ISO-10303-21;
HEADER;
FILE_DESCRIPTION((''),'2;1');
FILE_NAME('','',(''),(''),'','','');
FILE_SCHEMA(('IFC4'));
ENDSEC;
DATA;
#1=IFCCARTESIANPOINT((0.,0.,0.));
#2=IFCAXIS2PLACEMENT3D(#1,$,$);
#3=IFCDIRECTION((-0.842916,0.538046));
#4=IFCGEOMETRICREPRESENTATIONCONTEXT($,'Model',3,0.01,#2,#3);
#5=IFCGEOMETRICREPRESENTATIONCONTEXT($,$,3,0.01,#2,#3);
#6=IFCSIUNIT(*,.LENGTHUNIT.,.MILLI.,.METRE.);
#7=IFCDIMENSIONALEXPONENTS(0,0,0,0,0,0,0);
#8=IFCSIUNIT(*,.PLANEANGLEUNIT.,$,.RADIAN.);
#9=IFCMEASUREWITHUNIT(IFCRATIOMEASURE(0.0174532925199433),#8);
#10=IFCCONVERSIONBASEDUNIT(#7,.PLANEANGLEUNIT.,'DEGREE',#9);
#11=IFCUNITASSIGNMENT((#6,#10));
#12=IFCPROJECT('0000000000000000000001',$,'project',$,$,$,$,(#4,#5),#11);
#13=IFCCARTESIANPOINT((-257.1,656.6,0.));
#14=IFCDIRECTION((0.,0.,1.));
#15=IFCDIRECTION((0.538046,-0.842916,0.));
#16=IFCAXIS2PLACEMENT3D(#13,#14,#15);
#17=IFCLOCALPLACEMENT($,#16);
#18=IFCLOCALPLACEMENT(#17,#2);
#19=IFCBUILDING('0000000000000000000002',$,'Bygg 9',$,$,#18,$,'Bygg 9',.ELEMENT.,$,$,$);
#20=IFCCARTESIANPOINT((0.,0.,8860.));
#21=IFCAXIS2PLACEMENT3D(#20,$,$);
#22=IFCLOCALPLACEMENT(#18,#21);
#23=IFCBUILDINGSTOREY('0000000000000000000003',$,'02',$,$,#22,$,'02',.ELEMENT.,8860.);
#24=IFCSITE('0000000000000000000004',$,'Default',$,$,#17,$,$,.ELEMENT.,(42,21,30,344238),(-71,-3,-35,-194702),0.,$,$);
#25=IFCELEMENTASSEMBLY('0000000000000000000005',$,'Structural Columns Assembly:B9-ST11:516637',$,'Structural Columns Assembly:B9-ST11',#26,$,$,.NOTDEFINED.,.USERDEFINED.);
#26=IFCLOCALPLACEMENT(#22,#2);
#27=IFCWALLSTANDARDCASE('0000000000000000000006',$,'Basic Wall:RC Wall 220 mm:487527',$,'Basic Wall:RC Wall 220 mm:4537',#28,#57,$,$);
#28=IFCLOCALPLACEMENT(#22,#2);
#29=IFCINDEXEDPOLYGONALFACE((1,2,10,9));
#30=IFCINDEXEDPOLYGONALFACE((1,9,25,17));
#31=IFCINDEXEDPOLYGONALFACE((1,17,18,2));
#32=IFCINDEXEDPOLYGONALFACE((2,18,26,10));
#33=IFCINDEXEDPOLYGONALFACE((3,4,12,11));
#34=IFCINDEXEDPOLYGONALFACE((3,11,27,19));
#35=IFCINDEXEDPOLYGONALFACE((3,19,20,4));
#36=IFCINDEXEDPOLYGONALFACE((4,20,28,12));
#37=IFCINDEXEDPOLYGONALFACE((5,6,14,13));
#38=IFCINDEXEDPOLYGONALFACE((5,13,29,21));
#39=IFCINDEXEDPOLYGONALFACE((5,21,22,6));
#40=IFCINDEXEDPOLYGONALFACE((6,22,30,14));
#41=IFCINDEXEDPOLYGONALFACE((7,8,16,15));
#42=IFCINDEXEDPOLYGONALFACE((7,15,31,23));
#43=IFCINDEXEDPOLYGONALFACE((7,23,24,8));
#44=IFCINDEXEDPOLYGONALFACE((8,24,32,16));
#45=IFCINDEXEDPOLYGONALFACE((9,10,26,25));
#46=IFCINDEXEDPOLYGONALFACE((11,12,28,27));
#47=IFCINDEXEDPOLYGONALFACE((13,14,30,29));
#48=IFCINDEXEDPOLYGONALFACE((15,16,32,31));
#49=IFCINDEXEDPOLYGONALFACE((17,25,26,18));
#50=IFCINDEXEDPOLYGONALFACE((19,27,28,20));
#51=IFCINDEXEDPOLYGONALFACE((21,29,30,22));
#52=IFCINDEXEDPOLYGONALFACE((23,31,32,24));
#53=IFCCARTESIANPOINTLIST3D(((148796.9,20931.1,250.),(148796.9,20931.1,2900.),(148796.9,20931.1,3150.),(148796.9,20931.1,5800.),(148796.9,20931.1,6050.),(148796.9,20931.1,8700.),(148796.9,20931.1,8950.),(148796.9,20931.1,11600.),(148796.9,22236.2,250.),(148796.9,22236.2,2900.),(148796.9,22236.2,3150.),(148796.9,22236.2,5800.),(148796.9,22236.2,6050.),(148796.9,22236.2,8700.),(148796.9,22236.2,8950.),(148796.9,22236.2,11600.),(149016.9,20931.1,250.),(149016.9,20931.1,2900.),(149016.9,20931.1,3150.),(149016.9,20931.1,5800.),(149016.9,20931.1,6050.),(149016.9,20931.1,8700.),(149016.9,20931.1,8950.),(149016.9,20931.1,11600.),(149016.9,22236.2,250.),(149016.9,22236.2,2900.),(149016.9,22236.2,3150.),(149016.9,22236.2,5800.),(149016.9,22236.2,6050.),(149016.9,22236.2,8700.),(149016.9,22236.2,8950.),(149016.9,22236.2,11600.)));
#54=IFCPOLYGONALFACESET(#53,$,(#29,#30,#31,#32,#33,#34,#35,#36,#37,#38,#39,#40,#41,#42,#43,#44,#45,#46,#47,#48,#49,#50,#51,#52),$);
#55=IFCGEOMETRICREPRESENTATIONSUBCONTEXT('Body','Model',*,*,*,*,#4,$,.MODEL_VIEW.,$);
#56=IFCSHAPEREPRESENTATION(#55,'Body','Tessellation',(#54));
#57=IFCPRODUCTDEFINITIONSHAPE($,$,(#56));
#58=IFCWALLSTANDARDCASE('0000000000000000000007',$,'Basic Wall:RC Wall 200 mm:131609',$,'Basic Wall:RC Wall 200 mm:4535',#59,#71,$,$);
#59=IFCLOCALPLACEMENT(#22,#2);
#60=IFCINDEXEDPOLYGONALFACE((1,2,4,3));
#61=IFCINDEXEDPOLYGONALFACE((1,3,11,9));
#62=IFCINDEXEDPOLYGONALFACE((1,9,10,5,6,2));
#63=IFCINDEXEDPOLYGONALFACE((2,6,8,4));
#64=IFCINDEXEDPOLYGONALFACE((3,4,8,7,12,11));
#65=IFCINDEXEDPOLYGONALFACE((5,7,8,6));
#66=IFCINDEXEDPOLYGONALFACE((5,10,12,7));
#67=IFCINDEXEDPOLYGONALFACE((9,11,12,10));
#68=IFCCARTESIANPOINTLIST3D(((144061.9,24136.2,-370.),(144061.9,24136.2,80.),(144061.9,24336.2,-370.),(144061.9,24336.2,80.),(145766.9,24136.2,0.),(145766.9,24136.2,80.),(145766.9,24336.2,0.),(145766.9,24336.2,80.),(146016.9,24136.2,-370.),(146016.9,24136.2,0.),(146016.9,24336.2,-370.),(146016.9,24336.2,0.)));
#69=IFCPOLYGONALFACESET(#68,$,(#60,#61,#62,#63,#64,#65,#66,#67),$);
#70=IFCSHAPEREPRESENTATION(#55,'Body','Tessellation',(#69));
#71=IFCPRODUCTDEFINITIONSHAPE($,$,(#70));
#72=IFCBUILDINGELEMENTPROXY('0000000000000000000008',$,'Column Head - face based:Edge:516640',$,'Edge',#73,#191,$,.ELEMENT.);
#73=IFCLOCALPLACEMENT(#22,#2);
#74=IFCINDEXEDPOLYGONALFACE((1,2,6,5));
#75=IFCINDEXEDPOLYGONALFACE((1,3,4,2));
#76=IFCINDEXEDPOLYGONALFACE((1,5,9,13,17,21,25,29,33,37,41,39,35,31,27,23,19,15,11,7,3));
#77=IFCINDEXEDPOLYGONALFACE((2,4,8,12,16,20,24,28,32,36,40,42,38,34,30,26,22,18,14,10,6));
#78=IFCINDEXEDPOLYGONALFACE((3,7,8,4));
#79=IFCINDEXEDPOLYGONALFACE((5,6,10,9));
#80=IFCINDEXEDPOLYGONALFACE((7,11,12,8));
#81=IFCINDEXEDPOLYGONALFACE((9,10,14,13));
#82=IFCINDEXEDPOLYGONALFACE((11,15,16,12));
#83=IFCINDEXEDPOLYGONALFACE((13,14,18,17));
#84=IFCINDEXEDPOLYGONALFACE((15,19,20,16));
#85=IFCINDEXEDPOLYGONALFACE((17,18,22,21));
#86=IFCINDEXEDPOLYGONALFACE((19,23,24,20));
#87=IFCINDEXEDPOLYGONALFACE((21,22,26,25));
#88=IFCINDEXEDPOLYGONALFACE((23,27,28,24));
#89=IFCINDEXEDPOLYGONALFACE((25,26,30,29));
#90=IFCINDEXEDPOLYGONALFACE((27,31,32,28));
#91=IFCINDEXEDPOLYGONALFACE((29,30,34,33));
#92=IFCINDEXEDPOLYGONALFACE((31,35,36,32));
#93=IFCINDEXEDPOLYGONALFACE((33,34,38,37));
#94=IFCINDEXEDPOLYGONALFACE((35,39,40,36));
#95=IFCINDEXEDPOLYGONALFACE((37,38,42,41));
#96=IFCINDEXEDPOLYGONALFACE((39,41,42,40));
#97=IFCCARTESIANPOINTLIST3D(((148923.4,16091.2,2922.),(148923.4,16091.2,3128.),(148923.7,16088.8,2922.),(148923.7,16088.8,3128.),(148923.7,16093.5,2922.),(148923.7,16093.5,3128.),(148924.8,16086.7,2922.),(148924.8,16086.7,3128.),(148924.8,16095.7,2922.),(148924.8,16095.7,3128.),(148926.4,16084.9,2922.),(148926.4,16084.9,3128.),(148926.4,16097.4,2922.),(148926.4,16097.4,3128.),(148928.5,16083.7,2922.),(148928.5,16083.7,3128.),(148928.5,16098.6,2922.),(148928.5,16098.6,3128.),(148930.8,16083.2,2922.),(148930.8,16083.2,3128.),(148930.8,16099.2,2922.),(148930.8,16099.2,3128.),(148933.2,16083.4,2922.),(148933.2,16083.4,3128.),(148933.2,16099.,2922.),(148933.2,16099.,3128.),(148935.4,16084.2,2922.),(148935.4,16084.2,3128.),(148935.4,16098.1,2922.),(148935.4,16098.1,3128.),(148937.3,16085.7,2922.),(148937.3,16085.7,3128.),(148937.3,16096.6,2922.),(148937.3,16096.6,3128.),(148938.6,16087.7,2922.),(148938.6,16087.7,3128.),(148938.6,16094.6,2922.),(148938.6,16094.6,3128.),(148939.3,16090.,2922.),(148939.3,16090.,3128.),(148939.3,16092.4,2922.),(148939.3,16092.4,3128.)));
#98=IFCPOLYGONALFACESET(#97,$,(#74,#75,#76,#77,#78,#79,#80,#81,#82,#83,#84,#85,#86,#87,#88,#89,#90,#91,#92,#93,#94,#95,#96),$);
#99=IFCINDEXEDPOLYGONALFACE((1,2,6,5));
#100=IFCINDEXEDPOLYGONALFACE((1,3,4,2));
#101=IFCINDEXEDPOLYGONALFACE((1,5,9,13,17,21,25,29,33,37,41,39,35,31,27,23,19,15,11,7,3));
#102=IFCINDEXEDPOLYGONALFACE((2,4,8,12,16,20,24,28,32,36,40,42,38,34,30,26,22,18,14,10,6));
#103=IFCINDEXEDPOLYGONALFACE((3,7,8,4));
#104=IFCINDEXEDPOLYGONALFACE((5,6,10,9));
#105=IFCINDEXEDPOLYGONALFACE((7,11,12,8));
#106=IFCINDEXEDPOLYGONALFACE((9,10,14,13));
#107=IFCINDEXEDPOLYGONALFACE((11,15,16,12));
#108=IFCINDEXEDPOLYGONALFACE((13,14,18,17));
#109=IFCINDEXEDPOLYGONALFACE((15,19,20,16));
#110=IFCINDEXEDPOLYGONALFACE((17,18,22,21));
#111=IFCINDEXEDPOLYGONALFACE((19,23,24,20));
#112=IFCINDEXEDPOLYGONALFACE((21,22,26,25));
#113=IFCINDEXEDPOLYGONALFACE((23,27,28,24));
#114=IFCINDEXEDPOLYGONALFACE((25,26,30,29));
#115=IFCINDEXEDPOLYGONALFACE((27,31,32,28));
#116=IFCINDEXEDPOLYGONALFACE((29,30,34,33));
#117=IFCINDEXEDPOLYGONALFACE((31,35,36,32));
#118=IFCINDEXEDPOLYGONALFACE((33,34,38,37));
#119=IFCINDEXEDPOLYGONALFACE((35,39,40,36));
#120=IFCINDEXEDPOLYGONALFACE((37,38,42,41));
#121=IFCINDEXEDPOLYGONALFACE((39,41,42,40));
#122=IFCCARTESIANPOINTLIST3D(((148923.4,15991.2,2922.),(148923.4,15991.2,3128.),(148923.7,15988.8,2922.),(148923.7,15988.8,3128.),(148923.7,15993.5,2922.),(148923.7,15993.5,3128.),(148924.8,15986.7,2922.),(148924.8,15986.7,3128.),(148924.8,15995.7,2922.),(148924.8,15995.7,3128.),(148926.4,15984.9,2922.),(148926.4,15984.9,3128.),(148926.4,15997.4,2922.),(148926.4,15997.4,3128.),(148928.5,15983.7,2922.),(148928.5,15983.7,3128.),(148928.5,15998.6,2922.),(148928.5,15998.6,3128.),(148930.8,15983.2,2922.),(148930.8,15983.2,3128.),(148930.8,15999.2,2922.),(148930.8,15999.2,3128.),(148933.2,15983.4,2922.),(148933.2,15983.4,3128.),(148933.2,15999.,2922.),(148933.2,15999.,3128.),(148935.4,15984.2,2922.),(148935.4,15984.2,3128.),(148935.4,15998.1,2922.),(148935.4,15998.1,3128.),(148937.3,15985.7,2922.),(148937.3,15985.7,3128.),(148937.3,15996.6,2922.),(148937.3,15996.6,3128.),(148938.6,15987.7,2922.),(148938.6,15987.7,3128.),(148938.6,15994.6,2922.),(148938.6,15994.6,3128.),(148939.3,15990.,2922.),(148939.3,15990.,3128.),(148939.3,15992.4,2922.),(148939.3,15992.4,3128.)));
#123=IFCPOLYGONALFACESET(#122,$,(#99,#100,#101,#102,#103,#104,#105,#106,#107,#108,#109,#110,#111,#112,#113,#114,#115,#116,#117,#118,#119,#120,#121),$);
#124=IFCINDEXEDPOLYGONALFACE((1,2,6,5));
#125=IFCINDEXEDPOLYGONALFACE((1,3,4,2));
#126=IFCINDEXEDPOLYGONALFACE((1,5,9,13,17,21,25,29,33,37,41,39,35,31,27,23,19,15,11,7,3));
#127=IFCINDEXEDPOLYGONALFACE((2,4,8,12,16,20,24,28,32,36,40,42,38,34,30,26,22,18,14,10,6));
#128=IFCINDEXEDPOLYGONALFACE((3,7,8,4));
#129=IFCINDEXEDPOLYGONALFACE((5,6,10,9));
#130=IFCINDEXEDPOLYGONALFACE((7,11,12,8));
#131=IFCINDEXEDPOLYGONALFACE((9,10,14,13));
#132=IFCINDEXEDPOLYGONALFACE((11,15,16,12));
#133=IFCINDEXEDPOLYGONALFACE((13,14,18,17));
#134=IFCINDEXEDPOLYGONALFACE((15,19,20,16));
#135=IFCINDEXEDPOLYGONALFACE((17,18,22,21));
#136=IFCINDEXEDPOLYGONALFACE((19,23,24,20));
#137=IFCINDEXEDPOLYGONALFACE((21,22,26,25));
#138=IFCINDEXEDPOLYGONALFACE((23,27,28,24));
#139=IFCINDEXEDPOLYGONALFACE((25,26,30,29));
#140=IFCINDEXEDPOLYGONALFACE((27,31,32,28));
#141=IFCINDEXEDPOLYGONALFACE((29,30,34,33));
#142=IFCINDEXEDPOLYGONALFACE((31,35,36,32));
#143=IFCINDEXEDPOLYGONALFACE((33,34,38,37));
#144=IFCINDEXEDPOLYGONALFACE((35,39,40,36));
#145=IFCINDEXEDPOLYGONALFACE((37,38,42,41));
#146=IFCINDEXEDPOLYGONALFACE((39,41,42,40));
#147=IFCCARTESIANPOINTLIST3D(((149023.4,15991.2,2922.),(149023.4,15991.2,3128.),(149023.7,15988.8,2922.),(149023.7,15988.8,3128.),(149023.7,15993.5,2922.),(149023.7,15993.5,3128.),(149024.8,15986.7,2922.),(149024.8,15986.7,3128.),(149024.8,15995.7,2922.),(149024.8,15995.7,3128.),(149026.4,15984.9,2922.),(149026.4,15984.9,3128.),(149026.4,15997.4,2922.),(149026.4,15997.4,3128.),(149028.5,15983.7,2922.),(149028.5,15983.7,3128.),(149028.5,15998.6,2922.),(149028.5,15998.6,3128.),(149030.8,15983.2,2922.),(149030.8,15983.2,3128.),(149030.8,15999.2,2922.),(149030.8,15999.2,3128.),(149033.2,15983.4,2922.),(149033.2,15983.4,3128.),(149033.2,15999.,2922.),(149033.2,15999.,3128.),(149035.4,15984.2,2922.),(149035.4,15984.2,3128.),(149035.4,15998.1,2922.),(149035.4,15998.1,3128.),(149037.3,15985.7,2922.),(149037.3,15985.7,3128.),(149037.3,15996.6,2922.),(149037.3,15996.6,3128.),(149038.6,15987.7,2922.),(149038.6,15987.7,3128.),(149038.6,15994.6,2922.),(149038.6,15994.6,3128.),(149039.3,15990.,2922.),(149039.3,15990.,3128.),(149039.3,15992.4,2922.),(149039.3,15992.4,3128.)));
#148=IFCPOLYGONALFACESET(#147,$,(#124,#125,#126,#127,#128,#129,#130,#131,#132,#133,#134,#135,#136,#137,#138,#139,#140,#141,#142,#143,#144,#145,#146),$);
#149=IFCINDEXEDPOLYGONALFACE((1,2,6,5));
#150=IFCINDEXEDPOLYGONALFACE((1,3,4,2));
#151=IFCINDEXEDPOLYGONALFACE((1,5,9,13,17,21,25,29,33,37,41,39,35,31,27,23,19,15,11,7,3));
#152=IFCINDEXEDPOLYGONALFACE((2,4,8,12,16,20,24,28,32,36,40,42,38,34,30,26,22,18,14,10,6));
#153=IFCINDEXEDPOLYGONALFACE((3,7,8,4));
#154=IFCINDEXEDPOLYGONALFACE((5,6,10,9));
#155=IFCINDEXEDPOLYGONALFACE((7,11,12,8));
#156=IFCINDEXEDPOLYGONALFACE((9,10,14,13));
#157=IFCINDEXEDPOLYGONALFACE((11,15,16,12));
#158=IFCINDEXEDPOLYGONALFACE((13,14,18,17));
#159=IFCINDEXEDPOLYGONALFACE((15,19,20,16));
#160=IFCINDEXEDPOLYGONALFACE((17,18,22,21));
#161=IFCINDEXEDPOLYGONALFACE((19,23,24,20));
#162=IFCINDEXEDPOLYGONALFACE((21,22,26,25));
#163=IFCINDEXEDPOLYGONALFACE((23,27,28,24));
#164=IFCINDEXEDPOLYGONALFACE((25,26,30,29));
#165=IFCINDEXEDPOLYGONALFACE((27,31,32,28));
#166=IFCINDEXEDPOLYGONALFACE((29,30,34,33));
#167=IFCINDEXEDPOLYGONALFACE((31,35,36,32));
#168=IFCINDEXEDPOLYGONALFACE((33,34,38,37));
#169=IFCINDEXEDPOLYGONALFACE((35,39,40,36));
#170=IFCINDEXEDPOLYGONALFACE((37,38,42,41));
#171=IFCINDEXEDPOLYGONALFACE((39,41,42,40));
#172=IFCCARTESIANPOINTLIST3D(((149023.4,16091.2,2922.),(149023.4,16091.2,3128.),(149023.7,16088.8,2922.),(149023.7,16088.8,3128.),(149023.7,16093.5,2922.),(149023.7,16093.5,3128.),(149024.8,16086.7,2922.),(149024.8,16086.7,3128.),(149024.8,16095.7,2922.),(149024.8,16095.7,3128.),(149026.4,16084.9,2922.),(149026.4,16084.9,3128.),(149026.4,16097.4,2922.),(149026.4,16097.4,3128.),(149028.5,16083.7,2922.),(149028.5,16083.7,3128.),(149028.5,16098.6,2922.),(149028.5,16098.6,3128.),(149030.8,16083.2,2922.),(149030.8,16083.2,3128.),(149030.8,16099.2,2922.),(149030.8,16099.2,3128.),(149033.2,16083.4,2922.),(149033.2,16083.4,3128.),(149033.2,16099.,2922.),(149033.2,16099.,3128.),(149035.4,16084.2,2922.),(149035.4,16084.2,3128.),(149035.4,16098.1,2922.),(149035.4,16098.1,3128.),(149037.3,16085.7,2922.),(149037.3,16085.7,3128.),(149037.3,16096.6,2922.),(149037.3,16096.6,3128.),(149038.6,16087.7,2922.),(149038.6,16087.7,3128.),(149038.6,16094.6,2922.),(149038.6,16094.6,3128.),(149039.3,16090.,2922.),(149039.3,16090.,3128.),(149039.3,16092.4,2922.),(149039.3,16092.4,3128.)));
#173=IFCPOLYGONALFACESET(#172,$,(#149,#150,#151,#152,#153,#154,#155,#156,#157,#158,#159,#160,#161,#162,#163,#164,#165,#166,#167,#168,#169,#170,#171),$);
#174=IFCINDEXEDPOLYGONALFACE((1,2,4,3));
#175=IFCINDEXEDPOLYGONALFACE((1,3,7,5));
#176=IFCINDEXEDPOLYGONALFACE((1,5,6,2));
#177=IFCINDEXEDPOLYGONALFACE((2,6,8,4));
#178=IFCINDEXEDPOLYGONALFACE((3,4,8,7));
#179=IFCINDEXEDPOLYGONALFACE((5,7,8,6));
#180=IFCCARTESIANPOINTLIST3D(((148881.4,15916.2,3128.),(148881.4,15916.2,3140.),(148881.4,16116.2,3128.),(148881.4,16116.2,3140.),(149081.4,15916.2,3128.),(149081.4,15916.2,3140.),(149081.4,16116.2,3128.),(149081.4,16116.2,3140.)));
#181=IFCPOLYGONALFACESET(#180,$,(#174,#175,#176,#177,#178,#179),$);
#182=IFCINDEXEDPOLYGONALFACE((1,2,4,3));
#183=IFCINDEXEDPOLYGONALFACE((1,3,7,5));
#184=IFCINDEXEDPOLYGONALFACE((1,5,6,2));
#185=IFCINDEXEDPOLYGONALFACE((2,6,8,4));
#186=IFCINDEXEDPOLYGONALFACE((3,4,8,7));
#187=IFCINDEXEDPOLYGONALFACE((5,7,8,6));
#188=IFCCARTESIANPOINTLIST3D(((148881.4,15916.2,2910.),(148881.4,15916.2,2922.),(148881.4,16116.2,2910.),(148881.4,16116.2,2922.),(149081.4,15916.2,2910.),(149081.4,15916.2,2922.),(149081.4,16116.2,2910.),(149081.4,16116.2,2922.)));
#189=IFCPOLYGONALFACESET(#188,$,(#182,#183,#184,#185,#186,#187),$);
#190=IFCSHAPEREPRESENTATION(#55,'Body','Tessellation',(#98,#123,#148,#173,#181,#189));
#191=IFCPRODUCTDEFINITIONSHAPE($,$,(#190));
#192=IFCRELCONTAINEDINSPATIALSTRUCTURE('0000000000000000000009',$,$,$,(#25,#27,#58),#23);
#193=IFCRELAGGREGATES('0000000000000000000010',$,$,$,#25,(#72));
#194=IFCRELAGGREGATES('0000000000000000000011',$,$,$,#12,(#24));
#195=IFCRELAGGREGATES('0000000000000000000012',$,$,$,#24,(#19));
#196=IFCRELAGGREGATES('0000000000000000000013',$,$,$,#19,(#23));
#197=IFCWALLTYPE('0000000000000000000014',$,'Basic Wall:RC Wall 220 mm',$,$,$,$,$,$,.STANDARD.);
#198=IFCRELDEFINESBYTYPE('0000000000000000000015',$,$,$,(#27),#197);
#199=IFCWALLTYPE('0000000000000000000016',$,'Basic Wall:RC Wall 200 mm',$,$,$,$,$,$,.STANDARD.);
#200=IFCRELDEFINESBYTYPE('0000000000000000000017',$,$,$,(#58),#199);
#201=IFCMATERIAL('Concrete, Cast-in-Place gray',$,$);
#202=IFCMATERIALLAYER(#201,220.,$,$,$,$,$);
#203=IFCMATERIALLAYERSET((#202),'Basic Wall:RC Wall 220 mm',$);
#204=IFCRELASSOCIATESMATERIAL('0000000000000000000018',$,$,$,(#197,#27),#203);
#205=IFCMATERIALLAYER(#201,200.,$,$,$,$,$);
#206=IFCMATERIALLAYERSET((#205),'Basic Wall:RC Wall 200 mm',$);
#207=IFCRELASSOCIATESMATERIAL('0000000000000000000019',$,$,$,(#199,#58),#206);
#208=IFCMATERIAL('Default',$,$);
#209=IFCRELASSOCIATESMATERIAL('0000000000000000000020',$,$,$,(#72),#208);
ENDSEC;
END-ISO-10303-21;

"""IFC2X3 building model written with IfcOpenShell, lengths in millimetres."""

from ifc_helpers import new_model, entity, si_unit, converted_unit, direction, frame, frame_2d, origin, origin_2d_with_axis, place, context, subcontext, project, spatial, polyline, rectangle, circle, extrude, clip, bounded_halfspace, source, transform, mapped, material, layer, layer_set, layer_usage, type_object, element, aggregate, save


model = new_model("IFC2X3")

# Units and contexts
model_context = context("Model", 3, precision=0.01, world=origin(), true_north=direction((-0.842916, 0.538046)))
context_of_model = context(None, 3, precision=0.01, world=origin(), true_north=direction((-0.842916, 0.538046)))
body_context = subcontext(model_context, "Body", "Model", "MODEL_VIEW")
ifc_project = project(units=[si_unit("LENGTHUNIT", "METRE", prefix="MILLI"), converted_unit("PLANEANGLEUNIT", "DEGREE", entity("IfcRatioMeasure", 0.0174532925199433), si_unit("PLANEANGLEUNIT", "RADIAN"), dimensions=[0, 0, 0, 0, 0, 0, 0])], contexts=[model_context, context_of_model])

# Site, building, storey
site_placement = place(None, frame((-257.1, 656.6, 0.0), z_axis=(0.0, 0.0, 1.0), x_axis=(0.538046, -0.842916, 0.0)))
site = spatial("IfcSite", under=ifc_project, at=site_placement, Name="Default", CompositionType="ELEMENT", RefLatitude=(42, 21, 30, 344238), RefLongitude=(-71, -3, -35, -194702), RefElevation=0.0)
building_placement = place(site_placement, origin())
building = spatial("IfcBuilding", under=site, at=building_placement, Name="Bygg 9", LongName="Bygg 9", CompositionType="ELEMENT")
storey_placement = place(building_placement, frame((0.0, 0.0, 8860.0)))
storey = spatial("IfcBuildingStorey", under=building, at=storey_placement, Name="02", LongName="02", CompositionType="ELEMENT", Elevation=8860.0)

# Element assembly
assembly_1_placement = place(storey_placement, origin())
assembly_1 = element("IfcElementAssembly", 1, at=assembly_1_placement, inside=storey, Name="Structural Columns Assembly:B9-ST11:516637", ObjectType="Structural Columns Assembly:B9-ST11", AssemblyPlace="NOTDEFINED", PredefinedType="USERDEFINED")

# Wall, openings
ifc_material_1 = material(Name="Concrete, Cast-in-Place gray")
ifc_layer_1 = layer(ifc_material_1, 220.0)
ifc_layer_set_1 = layer_set([ifc_layer_1], Name="Basic Wall:RC Wall 220 mm")
wall_type_1 = type_object("IfcWallType", Name="Basic Wall:RC Wall 220 mm", PredefinedType="STANDARD", material=ifc_layer_set_1)
ifc_layer_usage_1 = layer_usage(ifc_layer_set_1, "AXIS2", "POSITIVE", -110.0)
wall_1_placement = place(storey_placement, frame((148906.9, 22236.2, 250.0), z_axis=(0.0, 0.0, 1.0), x_axis=(0.0, -1.0, 0.0)))
wall_1 = element("IfcWallStandardCase", 2, at=wall_1_placement, inside=storey, type_object=wall_type_1, material=ifc_layer_usage_1, Name="Basic Wall:RC Wall 220 mm:487527", ObjectType="Basic Wall:RC Wall 220 mm:4537", context=body_context, shape_type="Clipping", body=[
    clip(extrude(rectangle(XDim=1305.0, YDim=220.0, at=frame_2d((652.5, 0.0), x_axis=(-1.0, 0.0))), origin(), (0.0, 0.0, 1.0), 11350.0), bounded_halfspace(frame((0.0, -110.0, 11350.0), z_axis=(0.0, 0.0, -1.0), x_axis=(-0.99571, -0.092527, 0.0)), True, frame((0.0, -110.0, 11350.0)), polyline([(0.0, 0.0), (1305.0, 0.0), (1305.0, 220.0), (0.0, 220.0), (0.0, 0.0)]))),
])
opening_1_placement = place(storey_placement, frame((148906.9, 22236.2, 250.0), z_axis=(0.0, 0.0, 1.0), x_axis=(0.0, -1.0, 0.0)))
element("IfcOpeningElement", 3, at=opening_1_placement, cuts=wall_1, ObjectType="Opening", context=body_context, shape_type="SweptSolid", body=[
    extrude(rectangle(XDim=1305.0, YDim=220.0, at=frame_2d((0.0, 0.0), x_axis=(1.0, 0.0))), frame((652.5, 0.0, 2650.0)), (0.0, 0.0, 1.0), 250.0),
])
opening_2_placement = place(storey_placement, frame((148906.9, 22236.2, 250.0), z_axis=(0.0, 0.0, 1.0), x_axis=(0.0, -1.0, 0.0)))
element("IfcOpeningElement", 4, at=opening_2_placement, cuts=wall_1, ObjectType="Opening", context=body_context, shape_type="SweptSolid", body=[
    extrude(rectangle(XDim=1305.0, YDim=220.0, at=frame_2d((0.0, 0.0), x_axis=(1.0, 0.0))), frame((652.5, 0.0, 5550.0)), (0.0, 0.0, 1.0), 250.0),
])
opening_3_placement = place(storey_placement, frame((148906.9, 22236.2, 250.0), z_axis=(0.0, 0.0, 1.0), x_axis=(0.0, -1.0, 0.0)))
element("IfcOpeningElement", 5, at=opening_3_placement, cuts=wall_1, ObjectType="Opening", context=body_context, shape_type="SweptSolid", body=[
    extrude(rectangle(XDim=1305.0, YDim=220.0, at=frame_2d((0.0, 0.0), x_axis=(1.0, 0.0))), frame((652.5, 0.0, 8450.0)), (0.0, 0.0, 1.0), 250.0),
])

# Wall
ifc_layer_2 = layer(ifc_material_1, 200.0)
ifc_layer_set_2 = layer_set([ifc_layer_2], Name="Basic Wall:RC Wall 200 mm")
ifc_layer_usage_2 = layer_usage(ifc_layer_set_2, "AXIS2", "NEGATIVE", 100.0)
wall_type_2 = type_object("IfcWallType", Name="Basic Wall:RC Wall 200 mm", PredefinedType="STANDARD", material=ifc_layer_set_2)
wall_2_placement = place(storey_placement, frame((144061.9, 24236.2, -370.0)))
element("IfcWallStandardCase", 6, at=wall_2_placement, inside=storey, type_object=wall_type_2, material=ifc_layer_usage_2, Name="Basic Wall:RC Wall 200 mm:131609", ObjectType="Basic Wall:RC Wall 200 mm:4535", context=body_context, shape_type="Clipping", body=[
    clip(clip(extrude(rectangle(XDim=1955.0, YDim=200.0, at=frame_2d((977.5, 0.0), x_axis=(-1.0, 0.0))), origin(), (0.0, 0.0, 1.0), 450.0), bounded_halfspace(frame((0.0, -100.0, 450.0), z_axis=(0.0, 0.0, -1.0), x_axis=(0.0, -1.0, 0.0)), True, frame((0.0, -100.0, 450.0)), polyline([(0.0, 0.0), (1705.0, 0.0), (1705.0, 200.0), (0.0, 200.0), (0.0, 0.0)]))), bounded_halfspace(frame((1705.0, -100.0, 370.0), z_axis=(0.0, 0.0, 1.0), x_axis=(0.0, 1.0, 0.0)), False, frame((1705.0, -100.0, 370.0)), polyline([(0.0, 0.0), (250.0, 0.0), (250.0, 200.0), (0.0, 200.0), (0.0, 0.0)]))),
])

# Building element proxy
ifc_material_2 = material(Name="Default")
shared_shape_1 = source(origin(), body_context, "Body", "SweptSolid", [
    extrude(circle(Radius=8.0, at=frame_2d((0.0, 0.0), x_axis=(1.0, 0.0))), frame((50.0, -75.0, 12.0)), (0.0, 0.0, 1.0), 206.0),
    extrude(circle(Radius=8.0, at=frame_2d((0.0, 0.0), x_axis=(1.0, 0.0))), frame((50.0, 25.0, 12.0)), (0.0, 0.0, 1.0), 206.0),
    extrude(circle(Radius=8.0, at=frame_2d((0.0, 0.0), x_axis=(1.0, 0.0))), frame((-50.0, 25.0, 12.0)), (0.0, 0.0, 1.0), 206.0),
    extrude(circle(Radius=8.0, at=frame_2d((0.0, 0.0), x_axis=(1.0, 0.0))), frame((-50.0, -75.0, 12.0)), (0.0, 0.0, 1.0), 206.0),
    extrude(rectangle(XDim=200.0, YDim=200.0, at=origin_2d_with_axis()), frame((0.0, 0.0, 218.0), z_axis=(0.0, 0.0, 1.0), x_axis=(-1.0, 0.0, 0.0)), (0.0, 0.0, 1.0), 12.0),
    extrude(rectangle(XDim=200.0, YDim=200.0, at=origin_2d_with_axis()), frame((0.0, 0.0, 0.0), z_axis=(0.0, 0.0, 1.0), x_axis=(0.0, 1.0, 0.0)), (0.0, 0.0, 1.0), 12.0),
])
proxy_1_placement = place(assembly_1_placement, frame((148981.4, 16016.2, 2910.0), z_axis=(0.0, 0.0, 1.0), x_axis=(-1.0, 0.0, 0.0)))
proxy_1 = element("IfcBuildingElementProxy", 7, at=proxy_1_placement, material=ifc_material_2, Name="Column Head - face based:Edge:516640", ObjectType="Edge", CompositionType="ELEMENT", context=body_context, shape_type="MappedRepresentation", body=[
    mapped(shared_shape_1, transform((0.0, 0.0, 0.0), scale=1.0)),
])
aggregate(assembly_1, [proxy_1])

save(model, "model.ifc")
